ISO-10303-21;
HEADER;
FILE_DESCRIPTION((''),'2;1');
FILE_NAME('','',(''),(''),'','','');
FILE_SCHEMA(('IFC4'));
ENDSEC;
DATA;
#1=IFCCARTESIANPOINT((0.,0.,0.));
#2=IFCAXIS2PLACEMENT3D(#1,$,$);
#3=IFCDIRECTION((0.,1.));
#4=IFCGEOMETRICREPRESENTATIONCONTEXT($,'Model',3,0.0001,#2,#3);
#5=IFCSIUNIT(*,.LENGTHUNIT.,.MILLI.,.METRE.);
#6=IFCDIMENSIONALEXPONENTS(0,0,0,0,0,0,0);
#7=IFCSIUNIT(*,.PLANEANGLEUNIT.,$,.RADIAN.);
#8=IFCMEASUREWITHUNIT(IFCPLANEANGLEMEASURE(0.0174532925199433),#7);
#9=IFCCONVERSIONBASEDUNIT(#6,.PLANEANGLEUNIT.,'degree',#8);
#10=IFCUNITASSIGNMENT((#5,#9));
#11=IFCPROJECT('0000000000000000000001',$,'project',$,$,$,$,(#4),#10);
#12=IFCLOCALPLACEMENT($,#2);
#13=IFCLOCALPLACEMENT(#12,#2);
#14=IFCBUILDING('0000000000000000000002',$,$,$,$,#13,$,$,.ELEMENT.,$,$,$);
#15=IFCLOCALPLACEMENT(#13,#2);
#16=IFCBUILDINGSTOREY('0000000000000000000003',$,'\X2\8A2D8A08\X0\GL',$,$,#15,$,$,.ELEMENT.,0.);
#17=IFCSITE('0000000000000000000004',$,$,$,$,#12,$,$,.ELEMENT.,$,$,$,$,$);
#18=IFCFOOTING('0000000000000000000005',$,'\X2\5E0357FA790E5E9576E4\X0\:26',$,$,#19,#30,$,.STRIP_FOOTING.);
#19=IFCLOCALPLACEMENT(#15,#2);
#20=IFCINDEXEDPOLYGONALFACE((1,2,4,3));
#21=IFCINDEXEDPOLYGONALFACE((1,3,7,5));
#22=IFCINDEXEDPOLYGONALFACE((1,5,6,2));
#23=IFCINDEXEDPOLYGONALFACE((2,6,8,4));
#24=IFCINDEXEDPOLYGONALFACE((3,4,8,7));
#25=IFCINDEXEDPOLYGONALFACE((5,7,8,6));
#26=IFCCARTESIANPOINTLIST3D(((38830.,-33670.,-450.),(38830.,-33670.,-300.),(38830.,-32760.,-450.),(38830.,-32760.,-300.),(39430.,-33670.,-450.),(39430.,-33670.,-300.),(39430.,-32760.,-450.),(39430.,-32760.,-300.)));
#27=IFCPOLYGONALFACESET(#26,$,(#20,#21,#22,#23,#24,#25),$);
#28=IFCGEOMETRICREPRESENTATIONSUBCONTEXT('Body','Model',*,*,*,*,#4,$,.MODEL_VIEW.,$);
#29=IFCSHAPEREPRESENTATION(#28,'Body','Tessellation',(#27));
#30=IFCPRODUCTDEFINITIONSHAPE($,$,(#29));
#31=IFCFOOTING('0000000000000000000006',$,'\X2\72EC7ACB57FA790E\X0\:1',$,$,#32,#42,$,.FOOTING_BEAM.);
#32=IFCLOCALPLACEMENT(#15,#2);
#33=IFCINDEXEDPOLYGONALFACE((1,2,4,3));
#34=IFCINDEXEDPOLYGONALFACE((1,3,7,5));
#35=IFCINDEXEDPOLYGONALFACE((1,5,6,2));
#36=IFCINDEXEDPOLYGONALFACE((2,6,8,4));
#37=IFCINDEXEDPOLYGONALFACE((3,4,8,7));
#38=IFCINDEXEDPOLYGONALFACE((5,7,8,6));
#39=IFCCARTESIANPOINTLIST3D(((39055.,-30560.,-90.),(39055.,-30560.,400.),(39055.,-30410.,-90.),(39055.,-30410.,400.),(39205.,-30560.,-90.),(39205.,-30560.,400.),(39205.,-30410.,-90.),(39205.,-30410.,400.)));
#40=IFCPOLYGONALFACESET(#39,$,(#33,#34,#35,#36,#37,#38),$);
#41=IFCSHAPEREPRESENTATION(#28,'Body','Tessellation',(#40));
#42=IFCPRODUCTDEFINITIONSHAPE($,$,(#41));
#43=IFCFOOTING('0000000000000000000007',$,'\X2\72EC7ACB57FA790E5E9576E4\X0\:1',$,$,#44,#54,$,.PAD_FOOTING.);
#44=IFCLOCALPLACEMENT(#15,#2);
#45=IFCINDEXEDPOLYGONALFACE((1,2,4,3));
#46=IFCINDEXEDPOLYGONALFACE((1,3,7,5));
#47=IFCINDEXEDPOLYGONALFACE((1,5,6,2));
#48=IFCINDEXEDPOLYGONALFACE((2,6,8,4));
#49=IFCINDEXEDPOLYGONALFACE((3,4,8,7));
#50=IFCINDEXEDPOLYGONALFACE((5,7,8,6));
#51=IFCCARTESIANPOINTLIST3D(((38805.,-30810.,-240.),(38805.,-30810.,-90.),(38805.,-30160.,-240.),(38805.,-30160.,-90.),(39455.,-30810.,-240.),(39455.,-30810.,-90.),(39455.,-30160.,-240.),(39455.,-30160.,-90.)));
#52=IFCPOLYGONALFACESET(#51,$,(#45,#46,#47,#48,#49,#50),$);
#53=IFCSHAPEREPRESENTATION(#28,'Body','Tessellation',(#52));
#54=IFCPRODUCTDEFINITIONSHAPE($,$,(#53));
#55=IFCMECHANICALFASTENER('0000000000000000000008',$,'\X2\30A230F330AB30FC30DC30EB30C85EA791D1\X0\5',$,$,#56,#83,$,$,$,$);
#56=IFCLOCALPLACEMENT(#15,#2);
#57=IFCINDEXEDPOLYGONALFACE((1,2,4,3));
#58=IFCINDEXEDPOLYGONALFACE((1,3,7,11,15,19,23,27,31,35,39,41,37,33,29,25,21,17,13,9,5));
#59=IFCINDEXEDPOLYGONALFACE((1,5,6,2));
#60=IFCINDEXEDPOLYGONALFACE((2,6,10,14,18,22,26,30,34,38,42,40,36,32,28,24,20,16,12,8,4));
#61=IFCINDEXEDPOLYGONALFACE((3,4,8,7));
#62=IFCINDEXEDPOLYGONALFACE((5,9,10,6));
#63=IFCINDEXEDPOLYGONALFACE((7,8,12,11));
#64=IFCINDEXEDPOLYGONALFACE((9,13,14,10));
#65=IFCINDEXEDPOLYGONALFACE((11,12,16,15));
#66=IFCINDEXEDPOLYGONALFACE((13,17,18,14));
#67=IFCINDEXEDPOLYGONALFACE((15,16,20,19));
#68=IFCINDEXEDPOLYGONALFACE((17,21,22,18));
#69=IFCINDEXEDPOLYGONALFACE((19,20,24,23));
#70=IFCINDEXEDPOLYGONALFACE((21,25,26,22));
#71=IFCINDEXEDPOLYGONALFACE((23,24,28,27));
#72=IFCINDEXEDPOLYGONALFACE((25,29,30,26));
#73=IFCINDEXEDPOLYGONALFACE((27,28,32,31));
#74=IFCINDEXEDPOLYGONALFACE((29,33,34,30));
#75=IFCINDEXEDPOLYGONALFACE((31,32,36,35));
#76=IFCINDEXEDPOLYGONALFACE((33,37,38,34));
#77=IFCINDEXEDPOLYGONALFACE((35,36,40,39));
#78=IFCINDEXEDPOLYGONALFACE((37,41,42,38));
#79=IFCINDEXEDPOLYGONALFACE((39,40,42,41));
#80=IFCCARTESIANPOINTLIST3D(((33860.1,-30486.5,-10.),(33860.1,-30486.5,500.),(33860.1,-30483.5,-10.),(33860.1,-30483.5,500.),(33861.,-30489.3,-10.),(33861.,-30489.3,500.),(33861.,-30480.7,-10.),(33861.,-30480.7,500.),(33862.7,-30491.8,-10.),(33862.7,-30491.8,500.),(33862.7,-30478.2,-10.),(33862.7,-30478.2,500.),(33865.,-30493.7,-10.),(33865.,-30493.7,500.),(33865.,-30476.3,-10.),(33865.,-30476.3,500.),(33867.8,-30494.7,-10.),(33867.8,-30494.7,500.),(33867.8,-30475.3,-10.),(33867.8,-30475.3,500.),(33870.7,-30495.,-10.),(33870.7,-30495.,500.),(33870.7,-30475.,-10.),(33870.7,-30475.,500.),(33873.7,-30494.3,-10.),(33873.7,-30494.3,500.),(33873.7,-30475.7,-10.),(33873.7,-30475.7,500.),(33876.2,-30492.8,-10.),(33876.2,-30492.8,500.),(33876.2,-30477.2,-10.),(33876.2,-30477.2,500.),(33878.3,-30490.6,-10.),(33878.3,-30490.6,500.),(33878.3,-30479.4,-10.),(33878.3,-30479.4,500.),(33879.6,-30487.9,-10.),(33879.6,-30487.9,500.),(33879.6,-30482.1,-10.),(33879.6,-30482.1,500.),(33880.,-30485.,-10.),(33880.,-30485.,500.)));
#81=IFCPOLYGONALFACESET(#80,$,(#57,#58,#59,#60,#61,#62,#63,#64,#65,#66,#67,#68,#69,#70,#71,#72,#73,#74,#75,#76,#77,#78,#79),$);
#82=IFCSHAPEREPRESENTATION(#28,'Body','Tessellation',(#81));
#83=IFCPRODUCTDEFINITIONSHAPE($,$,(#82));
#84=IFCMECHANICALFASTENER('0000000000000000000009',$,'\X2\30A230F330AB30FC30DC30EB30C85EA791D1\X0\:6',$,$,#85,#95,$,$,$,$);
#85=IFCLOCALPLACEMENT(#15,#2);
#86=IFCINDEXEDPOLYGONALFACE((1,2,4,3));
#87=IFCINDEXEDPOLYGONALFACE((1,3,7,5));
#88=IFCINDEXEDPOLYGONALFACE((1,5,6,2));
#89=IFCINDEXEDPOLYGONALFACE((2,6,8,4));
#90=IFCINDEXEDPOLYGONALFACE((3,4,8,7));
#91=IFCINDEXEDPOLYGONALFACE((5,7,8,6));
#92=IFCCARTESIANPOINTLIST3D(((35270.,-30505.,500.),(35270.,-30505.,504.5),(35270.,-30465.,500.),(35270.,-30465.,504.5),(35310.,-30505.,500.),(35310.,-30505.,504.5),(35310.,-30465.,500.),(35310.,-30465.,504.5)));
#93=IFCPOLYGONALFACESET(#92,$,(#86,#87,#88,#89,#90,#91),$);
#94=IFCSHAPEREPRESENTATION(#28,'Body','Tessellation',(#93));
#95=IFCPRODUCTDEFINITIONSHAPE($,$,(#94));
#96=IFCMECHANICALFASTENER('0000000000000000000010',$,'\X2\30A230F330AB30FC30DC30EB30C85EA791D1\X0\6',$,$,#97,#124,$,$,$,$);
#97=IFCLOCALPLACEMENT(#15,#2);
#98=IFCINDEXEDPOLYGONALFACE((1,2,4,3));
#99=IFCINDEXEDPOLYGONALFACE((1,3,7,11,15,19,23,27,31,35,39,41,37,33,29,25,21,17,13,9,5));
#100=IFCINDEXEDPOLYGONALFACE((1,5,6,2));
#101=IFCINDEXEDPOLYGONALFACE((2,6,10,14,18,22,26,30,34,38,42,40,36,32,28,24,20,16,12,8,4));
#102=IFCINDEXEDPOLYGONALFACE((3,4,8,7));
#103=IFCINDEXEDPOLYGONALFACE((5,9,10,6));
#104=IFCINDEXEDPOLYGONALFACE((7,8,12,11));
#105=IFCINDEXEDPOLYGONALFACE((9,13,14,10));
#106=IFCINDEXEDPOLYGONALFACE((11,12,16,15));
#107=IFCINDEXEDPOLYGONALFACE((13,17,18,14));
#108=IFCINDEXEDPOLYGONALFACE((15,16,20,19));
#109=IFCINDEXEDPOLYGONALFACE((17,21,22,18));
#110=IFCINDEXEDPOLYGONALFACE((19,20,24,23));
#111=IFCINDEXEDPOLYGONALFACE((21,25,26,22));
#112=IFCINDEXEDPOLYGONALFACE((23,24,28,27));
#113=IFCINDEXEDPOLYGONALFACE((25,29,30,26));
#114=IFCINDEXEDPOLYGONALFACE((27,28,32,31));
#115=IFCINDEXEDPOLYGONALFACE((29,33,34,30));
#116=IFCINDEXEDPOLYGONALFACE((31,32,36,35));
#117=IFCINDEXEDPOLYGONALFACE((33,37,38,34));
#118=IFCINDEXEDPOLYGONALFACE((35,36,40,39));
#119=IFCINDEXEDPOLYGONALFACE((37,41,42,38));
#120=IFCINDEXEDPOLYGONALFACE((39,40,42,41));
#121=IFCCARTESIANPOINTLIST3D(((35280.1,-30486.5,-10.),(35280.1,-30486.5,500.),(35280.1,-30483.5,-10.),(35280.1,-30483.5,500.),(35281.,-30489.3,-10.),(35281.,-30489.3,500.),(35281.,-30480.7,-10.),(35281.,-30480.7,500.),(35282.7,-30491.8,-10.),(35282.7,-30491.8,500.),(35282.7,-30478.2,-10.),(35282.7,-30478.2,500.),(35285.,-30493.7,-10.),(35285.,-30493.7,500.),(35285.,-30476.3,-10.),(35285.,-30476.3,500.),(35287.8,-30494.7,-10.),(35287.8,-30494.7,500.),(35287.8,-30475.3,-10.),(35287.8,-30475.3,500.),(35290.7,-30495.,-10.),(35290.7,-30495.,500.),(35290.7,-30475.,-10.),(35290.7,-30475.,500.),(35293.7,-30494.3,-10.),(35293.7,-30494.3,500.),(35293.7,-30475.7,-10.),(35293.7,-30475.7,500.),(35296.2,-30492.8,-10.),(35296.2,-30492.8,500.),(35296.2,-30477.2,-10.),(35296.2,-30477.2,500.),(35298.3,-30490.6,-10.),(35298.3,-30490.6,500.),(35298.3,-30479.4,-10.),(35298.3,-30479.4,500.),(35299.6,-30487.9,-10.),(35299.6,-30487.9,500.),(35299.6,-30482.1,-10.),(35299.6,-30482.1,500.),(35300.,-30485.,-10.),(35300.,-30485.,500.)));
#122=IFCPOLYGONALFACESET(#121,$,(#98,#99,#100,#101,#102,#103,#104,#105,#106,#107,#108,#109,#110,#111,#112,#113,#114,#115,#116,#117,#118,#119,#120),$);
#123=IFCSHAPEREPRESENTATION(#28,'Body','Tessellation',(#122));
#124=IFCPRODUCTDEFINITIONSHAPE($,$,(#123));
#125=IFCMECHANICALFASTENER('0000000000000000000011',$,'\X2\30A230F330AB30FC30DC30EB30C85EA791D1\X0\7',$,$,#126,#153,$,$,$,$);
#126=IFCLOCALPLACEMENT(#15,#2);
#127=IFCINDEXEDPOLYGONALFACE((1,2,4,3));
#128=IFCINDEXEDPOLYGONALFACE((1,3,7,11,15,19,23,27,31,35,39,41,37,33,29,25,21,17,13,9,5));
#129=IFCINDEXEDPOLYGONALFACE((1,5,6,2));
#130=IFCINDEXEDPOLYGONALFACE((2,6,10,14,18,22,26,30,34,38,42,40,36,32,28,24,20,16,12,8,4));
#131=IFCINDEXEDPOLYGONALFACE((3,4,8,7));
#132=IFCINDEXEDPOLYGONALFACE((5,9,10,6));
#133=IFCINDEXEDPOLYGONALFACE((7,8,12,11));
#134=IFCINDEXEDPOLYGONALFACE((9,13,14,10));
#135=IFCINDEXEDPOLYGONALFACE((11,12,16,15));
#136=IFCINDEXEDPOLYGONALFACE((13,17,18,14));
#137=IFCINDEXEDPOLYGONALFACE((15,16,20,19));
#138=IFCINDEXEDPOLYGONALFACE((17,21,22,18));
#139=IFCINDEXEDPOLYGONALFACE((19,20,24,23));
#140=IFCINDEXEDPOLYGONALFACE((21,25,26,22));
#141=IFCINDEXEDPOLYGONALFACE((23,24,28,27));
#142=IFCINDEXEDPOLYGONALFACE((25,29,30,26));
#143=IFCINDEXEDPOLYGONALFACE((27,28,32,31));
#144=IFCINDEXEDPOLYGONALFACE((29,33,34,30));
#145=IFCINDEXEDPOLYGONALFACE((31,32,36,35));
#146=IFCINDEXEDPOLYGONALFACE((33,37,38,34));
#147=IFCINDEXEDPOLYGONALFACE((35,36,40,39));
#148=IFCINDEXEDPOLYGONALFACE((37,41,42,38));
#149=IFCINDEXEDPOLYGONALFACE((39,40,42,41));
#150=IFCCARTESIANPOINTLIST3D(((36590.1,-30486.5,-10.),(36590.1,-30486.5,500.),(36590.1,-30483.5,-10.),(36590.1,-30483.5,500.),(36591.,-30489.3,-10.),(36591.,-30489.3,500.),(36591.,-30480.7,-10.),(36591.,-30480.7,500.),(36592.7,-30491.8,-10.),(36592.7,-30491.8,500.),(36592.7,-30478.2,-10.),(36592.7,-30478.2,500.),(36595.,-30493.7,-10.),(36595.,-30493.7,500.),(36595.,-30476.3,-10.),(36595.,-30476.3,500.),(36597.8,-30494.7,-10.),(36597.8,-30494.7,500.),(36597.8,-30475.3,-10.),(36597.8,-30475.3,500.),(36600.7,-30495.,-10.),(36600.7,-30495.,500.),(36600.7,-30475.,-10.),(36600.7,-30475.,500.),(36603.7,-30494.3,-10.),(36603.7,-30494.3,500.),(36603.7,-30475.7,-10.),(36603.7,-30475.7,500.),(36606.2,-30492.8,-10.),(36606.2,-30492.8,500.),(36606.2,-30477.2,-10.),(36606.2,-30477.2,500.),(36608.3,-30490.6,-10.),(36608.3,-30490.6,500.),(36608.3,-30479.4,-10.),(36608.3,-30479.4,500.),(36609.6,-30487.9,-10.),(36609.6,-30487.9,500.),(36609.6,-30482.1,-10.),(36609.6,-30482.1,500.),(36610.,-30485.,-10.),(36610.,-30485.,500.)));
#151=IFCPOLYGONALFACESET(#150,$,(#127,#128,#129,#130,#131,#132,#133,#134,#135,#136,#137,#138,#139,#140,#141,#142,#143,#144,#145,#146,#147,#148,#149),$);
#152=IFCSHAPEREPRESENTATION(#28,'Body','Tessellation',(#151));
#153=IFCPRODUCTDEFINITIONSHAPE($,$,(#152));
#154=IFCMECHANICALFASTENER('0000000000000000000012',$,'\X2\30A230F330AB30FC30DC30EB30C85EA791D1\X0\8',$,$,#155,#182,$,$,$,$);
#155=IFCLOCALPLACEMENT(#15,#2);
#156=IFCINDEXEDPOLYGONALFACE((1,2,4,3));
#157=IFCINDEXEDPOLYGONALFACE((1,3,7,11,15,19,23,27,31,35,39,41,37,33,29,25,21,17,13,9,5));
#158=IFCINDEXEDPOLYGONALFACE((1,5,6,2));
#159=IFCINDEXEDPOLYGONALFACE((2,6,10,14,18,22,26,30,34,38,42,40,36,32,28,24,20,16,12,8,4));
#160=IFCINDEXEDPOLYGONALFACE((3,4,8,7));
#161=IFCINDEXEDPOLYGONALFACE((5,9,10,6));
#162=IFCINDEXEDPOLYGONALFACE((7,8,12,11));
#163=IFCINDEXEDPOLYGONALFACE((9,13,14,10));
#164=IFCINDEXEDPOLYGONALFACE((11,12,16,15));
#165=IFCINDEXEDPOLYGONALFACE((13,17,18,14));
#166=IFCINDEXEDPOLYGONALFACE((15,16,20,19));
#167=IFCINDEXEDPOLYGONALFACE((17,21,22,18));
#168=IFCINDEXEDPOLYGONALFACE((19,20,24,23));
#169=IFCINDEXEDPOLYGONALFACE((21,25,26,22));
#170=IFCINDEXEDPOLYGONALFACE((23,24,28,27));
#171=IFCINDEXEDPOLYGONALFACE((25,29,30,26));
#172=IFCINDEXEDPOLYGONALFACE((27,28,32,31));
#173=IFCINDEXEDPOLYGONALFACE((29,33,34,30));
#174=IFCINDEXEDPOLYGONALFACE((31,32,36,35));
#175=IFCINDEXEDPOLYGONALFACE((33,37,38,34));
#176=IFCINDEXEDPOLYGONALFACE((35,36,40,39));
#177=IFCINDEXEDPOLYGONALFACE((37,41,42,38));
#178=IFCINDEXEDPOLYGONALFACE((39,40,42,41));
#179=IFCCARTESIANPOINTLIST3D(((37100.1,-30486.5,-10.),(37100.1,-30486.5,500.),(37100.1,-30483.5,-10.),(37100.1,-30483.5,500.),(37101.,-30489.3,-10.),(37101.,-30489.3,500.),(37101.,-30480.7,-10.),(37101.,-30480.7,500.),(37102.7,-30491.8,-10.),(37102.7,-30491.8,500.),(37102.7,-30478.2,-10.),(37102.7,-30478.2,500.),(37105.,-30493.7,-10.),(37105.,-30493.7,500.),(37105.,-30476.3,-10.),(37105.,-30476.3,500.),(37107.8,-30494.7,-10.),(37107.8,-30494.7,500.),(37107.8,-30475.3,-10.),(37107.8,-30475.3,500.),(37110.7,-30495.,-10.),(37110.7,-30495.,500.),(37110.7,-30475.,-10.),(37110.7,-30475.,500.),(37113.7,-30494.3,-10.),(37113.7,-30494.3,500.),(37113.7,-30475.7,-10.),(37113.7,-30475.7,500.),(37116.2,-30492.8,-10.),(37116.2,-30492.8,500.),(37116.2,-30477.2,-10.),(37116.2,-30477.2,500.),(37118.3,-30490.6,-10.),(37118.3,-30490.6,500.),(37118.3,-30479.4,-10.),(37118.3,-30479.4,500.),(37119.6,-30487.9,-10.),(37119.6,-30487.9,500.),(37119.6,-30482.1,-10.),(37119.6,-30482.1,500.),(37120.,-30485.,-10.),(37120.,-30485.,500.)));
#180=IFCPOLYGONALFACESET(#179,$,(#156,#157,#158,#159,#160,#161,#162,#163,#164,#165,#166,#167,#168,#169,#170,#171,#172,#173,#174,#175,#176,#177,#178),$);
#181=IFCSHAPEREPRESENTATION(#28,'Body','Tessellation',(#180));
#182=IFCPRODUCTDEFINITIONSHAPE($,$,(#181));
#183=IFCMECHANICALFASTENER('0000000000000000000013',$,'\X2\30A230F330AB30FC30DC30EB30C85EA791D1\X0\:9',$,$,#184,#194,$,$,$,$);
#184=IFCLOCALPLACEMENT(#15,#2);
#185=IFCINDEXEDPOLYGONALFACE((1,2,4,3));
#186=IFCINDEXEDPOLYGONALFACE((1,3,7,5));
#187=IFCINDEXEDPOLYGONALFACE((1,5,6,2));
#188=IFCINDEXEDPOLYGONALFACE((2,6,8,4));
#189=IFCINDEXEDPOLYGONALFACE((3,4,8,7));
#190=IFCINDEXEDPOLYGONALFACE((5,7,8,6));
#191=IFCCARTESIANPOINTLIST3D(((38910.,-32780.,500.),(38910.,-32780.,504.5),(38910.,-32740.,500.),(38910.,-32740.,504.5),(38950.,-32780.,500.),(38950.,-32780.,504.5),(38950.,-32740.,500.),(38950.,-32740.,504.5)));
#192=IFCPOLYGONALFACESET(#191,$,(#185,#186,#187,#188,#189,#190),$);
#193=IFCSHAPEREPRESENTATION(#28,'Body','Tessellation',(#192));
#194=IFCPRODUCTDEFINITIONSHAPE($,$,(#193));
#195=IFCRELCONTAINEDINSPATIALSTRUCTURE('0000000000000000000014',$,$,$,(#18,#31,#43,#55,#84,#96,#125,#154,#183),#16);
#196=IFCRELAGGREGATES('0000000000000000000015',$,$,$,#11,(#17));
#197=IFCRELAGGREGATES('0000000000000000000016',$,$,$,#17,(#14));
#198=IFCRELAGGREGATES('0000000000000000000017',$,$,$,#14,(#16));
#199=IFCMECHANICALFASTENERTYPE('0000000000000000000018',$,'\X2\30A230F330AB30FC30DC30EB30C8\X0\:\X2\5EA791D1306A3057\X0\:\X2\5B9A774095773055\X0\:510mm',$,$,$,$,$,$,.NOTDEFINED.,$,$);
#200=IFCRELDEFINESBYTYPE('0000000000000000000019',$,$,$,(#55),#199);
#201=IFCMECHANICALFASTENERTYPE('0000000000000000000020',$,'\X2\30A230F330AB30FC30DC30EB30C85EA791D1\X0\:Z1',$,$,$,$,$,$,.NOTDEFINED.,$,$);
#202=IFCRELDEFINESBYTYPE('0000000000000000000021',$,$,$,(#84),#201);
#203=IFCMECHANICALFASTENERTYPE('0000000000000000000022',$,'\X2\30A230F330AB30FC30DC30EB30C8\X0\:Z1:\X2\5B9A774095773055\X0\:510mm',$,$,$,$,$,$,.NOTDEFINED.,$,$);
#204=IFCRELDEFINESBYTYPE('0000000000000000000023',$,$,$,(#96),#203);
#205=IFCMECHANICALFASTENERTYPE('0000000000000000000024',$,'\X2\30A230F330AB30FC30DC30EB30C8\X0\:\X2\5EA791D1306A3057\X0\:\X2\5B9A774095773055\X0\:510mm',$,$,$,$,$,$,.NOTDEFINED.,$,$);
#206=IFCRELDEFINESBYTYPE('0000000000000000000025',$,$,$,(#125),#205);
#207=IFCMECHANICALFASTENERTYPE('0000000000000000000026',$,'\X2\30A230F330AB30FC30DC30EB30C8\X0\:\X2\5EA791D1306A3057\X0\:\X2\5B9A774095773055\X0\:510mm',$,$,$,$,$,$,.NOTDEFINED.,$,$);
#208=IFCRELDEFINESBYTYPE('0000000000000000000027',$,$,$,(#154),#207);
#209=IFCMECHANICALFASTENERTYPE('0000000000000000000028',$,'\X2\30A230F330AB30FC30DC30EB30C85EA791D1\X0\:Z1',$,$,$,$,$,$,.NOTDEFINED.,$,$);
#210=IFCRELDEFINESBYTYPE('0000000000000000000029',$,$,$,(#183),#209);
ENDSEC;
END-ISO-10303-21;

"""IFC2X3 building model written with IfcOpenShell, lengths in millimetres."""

from ifc_helpers import new_model, entity, si_unit, converted_unit, direction, frame, origin, origin_with_axes, origin_2d, place, context, subcontext, project, spatial, rectangle, circle, extrude, type_object, element, save


model = new_model("IFC2X3")

# Units and contexts
model_context = context("Model", 3, precision=0.0001, world=origin(), true_north=direction((0.0, 1.0)))
body_context = subcontext(model_context, "Body", "Model", "MODEL_VIEW")
ifc_project = project(units=[si_unit("LENGTHUNIT", "METRE", prefix="MILLI"), converted_unit("PLANEANGLEUNIT", "degree", entity("IfcPlaneAngleMeasure", 0.0174532925199433), si_unit("PLANEANGLEUNIT", "RADIAN"), dimensions=[0, 0, 0, 0, 0, 0, 0])], contexts=[model_context])

# Site, building, storey
site_placement = place(None, origin())
site = spatial("IfcSite", under=ifc_project, at=site_placement, CompositionType="ELEMENT")
building_placement = place(site_placement, origin())
building = spatial("IfcBuilding", under=site, at=building_placement, CompositionType="ELEMENT")
storey_placement = place(building_placement, origin())
storey = spatial("IfcBuildingStorey", under=building, at=storey_placement, Name="設計GL", CompositionType="ELEMENT", Elevation=0.0)

# Footings
footing_1_placement = place(storey_placement, frame((39130.0, -32760.0, -375.0), z_axis=(0.0, -1.0, 0.0), x_axis=(-1.0, 0.0, 0.0)))
element("IfcFooting", 1, at=footing_1_placement, inside=storey, Name="布基礎底盤:26", PredefinedType="STRIP_FOOTING", context=body_context, shape_type="SweptSolid", body=[
    extrude(rectangle(XDim=600.0, YDim=150.0, at=origin_2d()), origin_with_axes(), (0.0, 0.0, 1.0), 910.0),
])
footing_2_placement = place(storey_placement, frame((39130.0, -30485.0, -90.0)))
element("IfcFooting", 2, at=footing_2_placement, inside=storey, Name="独立基礎:1", PredefinedType="FOOTING_BEAM", context=body_context, shape_type="SweptSolid", body=[
    extrude(rectangle(XDim=150.0, YDim=150.0, at=origin_2d()), origin_with_axes(), (0.0, 0.0, 1.0), 490.0),
])
footing_3_placement = place(storey_placement, frame((39130.0, -30485.0, -240.0)))
element("IfcFooting", 3, at=footing_3_placement, inside=storey, Name="独立基礎底盤:1", PredefinedType="PAD_FOOTING", context=body_context, shape_type="SweptSolid", body=[
    extrude(rectangle(XDim=650.0, YDim=650.0, at=origin_2d()), origin_with_axes(), (0.0, 0.0, 1.0), 150.0),
])

# Mechanical fasteners
mechanical_fastener_type_1 = type_object("IfcMechanicalFastenerType", Name="アンカーボルト:座金なし:定着長さ:510mm")
mechanical_fastener_1_placement = place(storey_placement, frame((33870.0, -30485.0, -10.0)))
element("IfcMechanicalFastener", 4, at=mechanical_fastener_1_placement, inside=storey, type_object=mechanical_fastener_type_1, Name="アンカーボルト座金5", context=body_context, shape_type="SweptSolid", body=[
    extrude(circle(Radius=10.0, at=origin_2d()), origin_with_axes(), (0.0, 0.0, 1.0), 510.0),
])
mechanical_fastener_type_2 = type_object("IfcMechanicalFastenerType", Name="アンカーボルト座金:Z1")
mechanical_fastener_2_placement = place(storey_placement, frame((35290.0, -30485.0, 500.0)))
element("IfcMechanicalFastener", 5, at=mechanical_fastener_2_placement, inside=storey, type_object=mechanical_fastener_type_2, Name="アンカーボルト座金:6", context=body_context, shape_type="SweptSolid", body=[
    extrude(rectangle(XDim=40.0, YDim=40.0, at=origin_2d()), origin_with_axes(), (0.0, 0.0, 1.0), 4.5),
])
mechanical_fastener_type_3 = type_object("IfcMechanicalFastenerType", Name="アンカーボルト:Z1:定着長さ:510mm")
mechanical_fastener_3_placement = place(storey_placement, frame((35290.0, -30485.0, -10.0)))
element("IfcMechanicalFastener", 6, at=mechanical_fastener_3_placement, inside=storey, type_object=mechanical_fastener_type_3, Name="アンカーボルト座金6", context=body_context, shape_type="SweptSolid", body=[
    extrude(circle(Radius=10.0, at=origin_2d()), origin_with_axes(), (0.0, 0.0, 1.0), 510.0),
])
mechanical_fastener_type_4 = type_object("IfcMechanicalFastenerType", Name="アンカーボルト:座金なし:定着長さ:510mm")
mechanical_fastener_4_placement = place(storey_placement, frame((36600.0, -30485.0, -10.0)))
element("IfcMechanicalFastener", 7, at=mechanical_fastener_4_placement, inside=storey, type_object=mechanical_fastener_type_4, Name="アンカーボルト座金7", context=body_context, shape_type="SweptSolid", body=[
    extrude(circle(Radius=10.0, at=origin_2d()), origin_with_axes(), (0.0, 0.0, 1.0), 510.0),
])
mechanical_fastener_type_5 = type_object("IfcMechanicalFastenerType", Name="アンカーボルト:座金なし:定着長さ:510mm")
mechanical_fastener_5_placement = place(storey_placement, frame((37110.0, -30485.0, -10.0)))
element("IfcMechanicalFastener", 8, at=mechanical_fastener_5_placement, inside=storey, type_object=mechanical_fastener_type_5, Name="アンカーボルト座金8", context=body_context, shape_type="SweptSolid", body=[
    extrude(circle(Radius=10.0, at=origin_2d()), origin_with_axes(), (0.0, 0.0, 1.0), 510.0),
])
mechanical_fastener_type_6 = type_object("IfcMechanicalFastenerType", Name="アンカーボルト座金:Z1")
mechanical_fastener_6_placement = place(storey_placement, frame((38930.0, -32760.0, 500.0)))
element("IfcMechanicalFastener", 9, at=mechanical_fastener_6_placement, inside=storey, type_object=mechanical_fastener_type_6, Name="アンカーボルト座金:9", context=body_context, shape_type="SweptSolid", body=[
    extrude(rectangle(XDim=40.0, YDim=40.0, at=origin_2d()), origin_with_axes(), (0.0, 0.0, 1.0), 4.5),
])

save(model, "model.ifc")
